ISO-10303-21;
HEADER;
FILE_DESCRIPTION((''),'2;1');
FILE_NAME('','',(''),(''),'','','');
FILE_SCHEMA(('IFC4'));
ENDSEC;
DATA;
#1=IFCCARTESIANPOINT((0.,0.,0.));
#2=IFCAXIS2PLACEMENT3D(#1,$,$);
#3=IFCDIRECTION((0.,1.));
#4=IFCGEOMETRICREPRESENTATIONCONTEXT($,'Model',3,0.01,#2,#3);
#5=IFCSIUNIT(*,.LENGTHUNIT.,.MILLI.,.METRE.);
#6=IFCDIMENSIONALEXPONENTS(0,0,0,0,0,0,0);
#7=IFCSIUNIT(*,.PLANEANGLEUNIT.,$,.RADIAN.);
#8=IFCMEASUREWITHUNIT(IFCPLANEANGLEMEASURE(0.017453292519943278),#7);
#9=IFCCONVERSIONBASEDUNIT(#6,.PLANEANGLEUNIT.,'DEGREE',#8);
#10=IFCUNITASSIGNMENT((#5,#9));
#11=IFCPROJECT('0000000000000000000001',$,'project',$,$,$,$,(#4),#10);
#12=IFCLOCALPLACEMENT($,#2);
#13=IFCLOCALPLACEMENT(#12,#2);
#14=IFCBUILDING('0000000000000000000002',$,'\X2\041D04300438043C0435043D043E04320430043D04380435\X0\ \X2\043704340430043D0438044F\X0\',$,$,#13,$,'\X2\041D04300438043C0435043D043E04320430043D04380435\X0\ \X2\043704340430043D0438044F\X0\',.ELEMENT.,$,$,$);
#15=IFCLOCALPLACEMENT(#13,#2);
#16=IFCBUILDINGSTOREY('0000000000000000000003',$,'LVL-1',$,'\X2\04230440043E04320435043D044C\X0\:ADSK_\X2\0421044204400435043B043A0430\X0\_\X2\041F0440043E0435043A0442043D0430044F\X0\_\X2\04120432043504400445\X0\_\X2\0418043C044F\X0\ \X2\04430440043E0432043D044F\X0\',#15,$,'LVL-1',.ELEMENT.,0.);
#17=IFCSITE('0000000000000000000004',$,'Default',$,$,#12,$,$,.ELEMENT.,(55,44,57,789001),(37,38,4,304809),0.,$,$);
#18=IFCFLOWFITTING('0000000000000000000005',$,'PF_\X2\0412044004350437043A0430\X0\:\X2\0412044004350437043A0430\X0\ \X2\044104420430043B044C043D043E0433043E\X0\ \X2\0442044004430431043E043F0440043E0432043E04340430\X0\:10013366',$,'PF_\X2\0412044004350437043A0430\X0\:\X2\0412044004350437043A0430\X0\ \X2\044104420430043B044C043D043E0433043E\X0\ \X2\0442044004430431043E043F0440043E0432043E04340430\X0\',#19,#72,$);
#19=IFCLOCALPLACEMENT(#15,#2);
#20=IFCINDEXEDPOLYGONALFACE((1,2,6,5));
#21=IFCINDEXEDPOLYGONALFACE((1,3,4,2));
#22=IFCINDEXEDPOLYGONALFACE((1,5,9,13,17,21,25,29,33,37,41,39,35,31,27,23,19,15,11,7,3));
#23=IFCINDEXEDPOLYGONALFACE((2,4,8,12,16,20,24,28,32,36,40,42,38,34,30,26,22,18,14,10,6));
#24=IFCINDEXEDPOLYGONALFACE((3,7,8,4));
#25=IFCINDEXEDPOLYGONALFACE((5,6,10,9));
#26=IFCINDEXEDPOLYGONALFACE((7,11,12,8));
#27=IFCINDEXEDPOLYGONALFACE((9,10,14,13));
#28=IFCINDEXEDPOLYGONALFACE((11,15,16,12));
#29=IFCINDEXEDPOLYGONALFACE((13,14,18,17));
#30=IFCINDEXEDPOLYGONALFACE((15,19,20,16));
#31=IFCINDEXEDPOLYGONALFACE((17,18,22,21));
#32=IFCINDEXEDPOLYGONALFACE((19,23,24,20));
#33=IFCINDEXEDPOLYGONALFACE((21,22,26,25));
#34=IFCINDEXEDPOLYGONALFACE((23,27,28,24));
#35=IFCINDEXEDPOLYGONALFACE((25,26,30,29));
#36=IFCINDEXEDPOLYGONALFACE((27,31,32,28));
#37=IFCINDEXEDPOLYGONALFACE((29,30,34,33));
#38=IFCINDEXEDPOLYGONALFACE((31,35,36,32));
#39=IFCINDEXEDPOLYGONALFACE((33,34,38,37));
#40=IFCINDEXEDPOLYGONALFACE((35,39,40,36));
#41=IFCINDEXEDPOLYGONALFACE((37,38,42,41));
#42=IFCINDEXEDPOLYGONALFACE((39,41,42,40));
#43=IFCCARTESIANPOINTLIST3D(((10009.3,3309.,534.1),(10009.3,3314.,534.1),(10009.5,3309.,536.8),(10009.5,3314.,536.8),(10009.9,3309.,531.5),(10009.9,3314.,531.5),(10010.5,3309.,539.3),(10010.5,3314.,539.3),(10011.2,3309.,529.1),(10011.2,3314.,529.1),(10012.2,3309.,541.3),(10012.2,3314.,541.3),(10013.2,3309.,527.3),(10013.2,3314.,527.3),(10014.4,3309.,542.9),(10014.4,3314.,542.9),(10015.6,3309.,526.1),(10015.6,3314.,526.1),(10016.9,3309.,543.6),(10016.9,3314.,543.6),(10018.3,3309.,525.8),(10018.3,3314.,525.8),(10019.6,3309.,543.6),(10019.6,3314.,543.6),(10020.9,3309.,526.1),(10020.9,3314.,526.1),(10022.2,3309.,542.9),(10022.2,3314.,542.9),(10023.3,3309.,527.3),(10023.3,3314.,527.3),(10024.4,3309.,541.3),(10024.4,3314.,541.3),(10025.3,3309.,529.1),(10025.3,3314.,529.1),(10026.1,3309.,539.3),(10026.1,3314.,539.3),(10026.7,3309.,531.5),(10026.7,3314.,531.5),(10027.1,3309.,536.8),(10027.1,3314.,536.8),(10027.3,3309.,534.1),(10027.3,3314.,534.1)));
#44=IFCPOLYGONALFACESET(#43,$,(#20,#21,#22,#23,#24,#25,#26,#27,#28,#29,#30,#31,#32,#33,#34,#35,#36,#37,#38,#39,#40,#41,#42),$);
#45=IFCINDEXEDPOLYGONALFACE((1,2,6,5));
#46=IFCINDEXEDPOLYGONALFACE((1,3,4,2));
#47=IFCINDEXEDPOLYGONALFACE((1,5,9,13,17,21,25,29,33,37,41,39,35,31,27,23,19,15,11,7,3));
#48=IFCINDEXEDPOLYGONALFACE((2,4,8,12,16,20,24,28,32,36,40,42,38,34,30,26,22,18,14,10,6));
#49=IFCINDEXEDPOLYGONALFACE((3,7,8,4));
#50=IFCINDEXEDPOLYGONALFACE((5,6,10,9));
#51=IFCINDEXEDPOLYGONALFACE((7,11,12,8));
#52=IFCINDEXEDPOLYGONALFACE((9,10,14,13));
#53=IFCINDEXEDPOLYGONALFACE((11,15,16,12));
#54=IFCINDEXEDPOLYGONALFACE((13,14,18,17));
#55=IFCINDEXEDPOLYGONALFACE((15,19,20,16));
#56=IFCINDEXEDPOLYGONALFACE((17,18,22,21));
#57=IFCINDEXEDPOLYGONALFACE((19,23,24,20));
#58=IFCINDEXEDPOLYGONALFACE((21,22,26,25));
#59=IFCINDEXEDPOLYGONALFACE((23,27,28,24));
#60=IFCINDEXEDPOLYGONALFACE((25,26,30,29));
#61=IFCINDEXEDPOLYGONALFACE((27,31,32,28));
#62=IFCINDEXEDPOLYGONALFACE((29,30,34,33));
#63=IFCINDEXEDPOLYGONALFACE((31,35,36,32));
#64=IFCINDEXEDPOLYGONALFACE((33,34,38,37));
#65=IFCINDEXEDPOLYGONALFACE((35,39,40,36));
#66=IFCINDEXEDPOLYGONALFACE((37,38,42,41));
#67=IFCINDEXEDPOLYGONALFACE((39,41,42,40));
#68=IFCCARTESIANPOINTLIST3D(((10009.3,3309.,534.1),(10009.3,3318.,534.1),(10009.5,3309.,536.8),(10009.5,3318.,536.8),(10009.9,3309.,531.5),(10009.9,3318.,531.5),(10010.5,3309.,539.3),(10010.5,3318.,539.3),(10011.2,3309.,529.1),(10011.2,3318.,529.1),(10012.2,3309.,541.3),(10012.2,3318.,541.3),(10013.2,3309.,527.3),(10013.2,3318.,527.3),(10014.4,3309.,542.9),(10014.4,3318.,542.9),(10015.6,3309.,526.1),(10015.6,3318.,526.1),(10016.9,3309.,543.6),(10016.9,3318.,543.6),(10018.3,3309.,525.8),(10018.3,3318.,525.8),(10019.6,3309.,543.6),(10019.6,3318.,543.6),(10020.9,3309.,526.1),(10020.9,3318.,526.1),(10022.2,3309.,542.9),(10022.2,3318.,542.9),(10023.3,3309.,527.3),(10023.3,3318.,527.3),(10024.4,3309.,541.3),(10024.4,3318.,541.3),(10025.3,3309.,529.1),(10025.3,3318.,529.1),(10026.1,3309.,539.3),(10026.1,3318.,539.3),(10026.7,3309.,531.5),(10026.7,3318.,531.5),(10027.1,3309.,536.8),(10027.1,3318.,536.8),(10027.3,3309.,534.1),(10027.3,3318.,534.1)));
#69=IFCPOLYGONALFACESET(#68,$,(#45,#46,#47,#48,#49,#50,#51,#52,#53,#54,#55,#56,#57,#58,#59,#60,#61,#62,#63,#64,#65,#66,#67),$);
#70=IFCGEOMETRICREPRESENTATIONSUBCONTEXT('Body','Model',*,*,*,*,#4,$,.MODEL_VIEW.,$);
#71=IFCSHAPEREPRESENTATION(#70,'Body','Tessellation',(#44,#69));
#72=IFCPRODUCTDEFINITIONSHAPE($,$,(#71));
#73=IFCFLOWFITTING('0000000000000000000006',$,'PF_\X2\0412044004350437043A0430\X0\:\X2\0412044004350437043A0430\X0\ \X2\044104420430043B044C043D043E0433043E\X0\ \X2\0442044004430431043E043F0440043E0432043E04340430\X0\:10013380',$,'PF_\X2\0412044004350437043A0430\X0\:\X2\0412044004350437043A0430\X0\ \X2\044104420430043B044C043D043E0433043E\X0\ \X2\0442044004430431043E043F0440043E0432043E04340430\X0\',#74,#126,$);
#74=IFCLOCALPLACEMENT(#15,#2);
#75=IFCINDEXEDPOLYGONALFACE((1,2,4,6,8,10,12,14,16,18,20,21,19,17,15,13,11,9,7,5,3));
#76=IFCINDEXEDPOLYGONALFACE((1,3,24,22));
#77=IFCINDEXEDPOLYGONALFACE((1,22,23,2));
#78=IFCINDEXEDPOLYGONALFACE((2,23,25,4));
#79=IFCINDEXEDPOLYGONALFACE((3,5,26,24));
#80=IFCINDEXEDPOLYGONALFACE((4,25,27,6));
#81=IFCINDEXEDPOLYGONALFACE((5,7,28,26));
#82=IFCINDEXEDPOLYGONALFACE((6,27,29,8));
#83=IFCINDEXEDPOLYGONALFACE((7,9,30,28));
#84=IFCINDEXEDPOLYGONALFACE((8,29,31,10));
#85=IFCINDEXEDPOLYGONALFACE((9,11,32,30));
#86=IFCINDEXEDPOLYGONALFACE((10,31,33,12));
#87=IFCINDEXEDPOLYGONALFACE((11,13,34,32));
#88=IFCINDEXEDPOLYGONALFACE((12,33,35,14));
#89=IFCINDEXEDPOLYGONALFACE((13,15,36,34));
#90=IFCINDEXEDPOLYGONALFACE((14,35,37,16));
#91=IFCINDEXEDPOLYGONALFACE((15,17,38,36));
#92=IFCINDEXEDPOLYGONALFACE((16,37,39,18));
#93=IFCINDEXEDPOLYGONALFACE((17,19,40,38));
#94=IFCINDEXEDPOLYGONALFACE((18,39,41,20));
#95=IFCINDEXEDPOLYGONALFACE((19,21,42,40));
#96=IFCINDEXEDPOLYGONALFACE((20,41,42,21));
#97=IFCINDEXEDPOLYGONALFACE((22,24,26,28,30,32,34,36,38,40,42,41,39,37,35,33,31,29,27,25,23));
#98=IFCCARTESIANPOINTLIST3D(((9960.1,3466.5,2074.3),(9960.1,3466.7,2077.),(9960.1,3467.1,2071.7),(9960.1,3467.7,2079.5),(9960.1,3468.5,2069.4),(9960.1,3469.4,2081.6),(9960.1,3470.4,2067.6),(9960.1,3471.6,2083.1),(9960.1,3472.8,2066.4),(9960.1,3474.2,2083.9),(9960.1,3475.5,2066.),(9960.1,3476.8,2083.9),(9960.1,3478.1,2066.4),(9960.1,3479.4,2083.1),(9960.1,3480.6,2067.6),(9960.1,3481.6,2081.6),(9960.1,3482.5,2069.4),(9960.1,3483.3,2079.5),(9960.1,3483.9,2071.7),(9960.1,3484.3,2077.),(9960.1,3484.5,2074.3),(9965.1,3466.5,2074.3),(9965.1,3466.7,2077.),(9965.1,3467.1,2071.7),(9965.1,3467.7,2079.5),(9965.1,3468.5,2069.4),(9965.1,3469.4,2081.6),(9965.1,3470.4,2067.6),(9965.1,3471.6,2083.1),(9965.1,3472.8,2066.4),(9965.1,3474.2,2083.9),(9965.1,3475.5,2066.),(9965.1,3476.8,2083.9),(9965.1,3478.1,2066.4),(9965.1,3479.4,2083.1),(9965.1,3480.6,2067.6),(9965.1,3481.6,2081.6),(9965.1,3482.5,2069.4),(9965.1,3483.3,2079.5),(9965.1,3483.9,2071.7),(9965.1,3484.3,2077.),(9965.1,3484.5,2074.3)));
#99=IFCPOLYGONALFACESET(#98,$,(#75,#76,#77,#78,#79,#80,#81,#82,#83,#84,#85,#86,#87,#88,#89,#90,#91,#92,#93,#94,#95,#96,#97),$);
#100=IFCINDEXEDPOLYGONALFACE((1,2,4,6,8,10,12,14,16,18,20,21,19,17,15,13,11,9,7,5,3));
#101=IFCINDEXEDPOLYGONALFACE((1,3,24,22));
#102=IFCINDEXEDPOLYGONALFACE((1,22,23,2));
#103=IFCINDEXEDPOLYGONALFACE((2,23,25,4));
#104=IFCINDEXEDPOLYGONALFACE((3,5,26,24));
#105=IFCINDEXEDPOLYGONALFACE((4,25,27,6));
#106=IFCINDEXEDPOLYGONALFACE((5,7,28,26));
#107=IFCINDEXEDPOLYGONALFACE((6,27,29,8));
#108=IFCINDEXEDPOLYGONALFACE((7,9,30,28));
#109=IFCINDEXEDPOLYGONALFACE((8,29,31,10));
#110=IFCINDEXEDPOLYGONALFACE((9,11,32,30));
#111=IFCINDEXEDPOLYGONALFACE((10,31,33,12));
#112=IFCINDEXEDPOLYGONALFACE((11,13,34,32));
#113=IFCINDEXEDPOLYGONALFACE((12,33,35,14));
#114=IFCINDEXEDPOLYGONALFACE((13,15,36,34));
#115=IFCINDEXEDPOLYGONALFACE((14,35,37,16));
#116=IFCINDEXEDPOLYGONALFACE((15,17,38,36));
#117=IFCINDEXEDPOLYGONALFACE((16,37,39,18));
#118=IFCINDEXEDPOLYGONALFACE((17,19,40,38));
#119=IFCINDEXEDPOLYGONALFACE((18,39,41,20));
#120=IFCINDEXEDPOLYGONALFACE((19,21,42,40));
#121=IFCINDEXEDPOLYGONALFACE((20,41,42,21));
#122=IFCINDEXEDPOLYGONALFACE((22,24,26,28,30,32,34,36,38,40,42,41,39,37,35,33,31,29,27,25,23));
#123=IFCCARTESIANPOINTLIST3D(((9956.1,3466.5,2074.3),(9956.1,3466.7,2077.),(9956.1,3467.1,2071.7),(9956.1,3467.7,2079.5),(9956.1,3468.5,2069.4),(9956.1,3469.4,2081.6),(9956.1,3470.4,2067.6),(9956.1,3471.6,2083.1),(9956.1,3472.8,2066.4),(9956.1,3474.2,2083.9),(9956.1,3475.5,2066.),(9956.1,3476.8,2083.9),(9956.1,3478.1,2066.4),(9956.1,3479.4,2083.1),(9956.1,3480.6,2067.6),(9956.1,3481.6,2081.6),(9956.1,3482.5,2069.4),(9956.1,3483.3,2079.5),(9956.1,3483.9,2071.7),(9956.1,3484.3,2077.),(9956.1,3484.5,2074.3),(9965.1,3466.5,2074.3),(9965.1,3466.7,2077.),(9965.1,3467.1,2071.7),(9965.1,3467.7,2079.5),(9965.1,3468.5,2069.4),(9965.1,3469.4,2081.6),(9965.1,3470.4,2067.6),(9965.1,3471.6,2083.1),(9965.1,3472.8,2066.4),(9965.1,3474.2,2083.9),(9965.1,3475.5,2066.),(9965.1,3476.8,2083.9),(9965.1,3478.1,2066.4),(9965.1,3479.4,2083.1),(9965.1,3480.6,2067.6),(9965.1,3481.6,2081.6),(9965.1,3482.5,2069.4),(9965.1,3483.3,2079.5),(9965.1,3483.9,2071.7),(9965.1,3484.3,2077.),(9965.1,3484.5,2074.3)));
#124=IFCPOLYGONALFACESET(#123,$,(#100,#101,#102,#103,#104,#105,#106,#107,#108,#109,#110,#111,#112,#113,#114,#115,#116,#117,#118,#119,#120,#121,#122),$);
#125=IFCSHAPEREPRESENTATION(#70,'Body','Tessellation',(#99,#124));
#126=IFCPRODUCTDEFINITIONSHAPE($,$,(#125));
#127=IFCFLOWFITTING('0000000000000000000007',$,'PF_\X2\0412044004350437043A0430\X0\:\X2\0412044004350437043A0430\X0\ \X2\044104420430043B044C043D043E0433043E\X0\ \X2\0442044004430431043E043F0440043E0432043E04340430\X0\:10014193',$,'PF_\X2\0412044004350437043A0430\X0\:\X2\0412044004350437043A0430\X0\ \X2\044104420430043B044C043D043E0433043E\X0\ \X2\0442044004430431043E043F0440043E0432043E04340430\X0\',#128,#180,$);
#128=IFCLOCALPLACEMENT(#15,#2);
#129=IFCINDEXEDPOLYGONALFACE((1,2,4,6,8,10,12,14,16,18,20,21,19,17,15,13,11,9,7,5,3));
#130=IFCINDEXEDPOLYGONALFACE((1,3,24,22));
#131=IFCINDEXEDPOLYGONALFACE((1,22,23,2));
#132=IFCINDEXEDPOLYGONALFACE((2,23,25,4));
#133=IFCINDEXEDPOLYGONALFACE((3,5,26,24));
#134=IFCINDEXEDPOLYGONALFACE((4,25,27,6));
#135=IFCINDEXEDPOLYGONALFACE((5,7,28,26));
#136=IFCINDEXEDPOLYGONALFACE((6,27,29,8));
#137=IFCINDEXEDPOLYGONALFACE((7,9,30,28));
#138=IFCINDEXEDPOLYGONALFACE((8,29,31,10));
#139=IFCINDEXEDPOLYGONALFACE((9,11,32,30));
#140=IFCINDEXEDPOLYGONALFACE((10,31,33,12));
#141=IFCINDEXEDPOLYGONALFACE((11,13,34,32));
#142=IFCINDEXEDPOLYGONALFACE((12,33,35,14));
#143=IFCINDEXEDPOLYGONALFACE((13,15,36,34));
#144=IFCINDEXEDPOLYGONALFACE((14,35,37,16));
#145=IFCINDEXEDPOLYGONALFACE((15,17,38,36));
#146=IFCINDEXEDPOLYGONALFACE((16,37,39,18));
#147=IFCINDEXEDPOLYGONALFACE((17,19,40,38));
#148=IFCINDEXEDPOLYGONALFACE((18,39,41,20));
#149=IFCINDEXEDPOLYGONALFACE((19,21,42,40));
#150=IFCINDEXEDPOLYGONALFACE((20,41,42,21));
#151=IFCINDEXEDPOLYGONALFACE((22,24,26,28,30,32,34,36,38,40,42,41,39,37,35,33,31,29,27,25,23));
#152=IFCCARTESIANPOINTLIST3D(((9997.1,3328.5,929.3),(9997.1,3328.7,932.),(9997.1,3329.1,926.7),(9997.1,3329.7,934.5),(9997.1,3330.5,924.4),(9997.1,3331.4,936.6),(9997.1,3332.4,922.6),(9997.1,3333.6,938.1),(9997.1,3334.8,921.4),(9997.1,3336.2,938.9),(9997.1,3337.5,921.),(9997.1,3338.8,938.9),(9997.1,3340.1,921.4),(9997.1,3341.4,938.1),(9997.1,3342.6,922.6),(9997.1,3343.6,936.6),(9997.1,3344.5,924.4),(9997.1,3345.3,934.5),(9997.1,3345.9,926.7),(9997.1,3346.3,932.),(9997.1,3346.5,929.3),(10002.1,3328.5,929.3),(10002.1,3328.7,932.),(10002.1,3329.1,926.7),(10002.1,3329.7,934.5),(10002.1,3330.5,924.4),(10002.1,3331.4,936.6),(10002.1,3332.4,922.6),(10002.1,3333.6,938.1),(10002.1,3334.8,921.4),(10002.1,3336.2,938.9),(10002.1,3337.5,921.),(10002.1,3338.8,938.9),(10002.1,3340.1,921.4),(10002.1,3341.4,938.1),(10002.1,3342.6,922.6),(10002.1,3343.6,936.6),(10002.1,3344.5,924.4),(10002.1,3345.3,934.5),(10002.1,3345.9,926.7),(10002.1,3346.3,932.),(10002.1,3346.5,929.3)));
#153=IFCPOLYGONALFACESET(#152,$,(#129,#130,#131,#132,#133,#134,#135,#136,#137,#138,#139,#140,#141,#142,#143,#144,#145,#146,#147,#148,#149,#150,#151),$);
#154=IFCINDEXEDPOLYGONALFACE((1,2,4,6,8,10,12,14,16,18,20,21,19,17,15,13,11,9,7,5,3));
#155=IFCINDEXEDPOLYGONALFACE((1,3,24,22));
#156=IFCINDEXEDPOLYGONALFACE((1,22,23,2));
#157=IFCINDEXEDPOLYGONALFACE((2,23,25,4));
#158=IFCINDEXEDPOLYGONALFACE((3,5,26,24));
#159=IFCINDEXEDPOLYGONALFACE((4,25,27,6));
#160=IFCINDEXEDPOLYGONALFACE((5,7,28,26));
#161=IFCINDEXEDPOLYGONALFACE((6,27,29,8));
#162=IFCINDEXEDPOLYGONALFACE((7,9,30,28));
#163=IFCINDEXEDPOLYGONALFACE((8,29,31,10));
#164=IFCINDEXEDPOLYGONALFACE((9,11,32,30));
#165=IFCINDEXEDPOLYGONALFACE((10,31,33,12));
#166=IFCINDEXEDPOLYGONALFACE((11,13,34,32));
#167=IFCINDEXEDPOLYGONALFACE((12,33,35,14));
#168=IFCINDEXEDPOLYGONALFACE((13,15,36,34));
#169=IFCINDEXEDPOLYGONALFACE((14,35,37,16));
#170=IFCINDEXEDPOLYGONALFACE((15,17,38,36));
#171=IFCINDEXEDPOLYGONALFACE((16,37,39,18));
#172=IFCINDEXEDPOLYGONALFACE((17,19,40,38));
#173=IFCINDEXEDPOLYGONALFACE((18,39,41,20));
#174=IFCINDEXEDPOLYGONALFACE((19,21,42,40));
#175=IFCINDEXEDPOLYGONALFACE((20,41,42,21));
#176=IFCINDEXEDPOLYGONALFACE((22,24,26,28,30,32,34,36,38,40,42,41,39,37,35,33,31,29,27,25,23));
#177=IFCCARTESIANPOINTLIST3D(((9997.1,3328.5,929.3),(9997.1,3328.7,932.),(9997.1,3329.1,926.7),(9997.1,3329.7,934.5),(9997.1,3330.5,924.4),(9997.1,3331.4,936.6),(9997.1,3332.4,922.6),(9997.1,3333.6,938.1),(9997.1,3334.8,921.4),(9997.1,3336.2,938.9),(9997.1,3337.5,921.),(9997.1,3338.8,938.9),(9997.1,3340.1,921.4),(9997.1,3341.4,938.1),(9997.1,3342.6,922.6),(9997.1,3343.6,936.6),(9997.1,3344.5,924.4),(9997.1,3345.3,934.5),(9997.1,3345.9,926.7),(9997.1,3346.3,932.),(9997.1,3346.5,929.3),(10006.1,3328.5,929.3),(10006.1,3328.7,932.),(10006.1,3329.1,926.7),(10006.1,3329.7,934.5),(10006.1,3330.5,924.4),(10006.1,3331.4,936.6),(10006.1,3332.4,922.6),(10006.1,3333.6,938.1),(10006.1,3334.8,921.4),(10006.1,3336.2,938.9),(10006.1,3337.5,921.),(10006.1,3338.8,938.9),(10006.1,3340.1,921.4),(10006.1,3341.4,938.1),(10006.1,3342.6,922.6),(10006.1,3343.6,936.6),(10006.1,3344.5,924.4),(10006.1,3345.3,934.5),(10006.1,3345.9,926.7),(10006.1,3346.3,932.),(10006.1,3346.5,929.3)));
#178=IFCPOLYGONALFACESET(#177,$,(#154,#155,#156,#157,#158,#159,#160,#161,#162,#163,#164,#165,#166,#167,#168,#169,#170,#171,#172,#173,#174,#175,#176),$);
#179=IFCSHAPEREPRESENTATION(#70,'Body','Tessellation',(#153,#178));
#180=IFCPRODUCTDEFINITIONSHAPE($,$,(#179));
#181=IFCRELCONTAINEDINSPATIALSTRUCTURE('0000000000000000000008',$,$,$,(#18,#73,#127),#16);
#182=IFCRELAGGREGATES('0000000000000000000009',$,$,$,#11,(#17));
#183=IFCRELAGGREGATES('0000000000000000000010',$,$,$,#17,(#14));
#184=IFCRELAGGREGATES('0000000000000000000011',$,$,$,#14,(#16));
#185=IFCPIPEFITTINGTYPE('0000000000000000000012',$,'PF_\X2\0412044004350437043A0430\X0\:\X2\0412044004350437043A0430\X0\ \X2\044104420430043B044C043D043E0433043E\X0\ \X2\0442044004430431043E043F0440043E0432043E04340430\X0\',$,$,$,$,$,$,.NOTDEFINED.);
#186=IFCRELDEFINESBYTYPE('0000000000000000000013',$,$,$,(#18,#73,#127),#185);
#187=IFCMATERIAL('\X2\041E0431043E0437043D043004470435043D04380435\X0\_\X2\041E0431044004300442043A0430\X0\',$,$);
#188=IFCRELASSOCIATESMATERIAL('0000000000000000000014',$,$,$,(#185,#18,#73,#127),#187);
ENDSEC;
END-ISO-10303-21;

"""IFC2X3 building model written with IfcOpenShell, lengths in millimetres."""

from ifc_helpers import new_model, entity, si_unit, converted_unit, direction, frame, frame_2d, origin, place, context, subcontext, project, spatial, circle, extrude, source, transform, mapped, material, type_object, type_shapes, element, save


model = new_model("IFC2X3")

# Units and contexts
model_context = context("Model", 3, precision=0.01, world=origin(), true_north=direction((0.0, 1.0)))
body_context = subcontext(model_context, "Body", "Model", "MODEL_VIEW")
ifc_project = project(units=[si_unit("LENGTHUNIT", "METRE", prefix="MILLI"), converted_unit("PLANEANGLEUNIT", "DEGREE", entity("IfcPlaneAngleMeasure", 0.017453292519943278), si_unit("PLANEANGLEUNIT", "RADIAN"), dimensions=[0, 0, 0, 0, 0, 0, 0])], contexts=[model_context])

# Site, building, storey
site_placement = place(None, origin())
site = spatial("IfcSite", under=ifc_project, at=site_placement, Name="Default", CompositionType="ELEMENT", RefLatitude=(55, 44, 57, 789001), RefLongitude=(37, 38, 4, 304809), RefElevation=0.0)
building_placement = place(site_placement, origin())
building = spatial("IfcBuilding", under=site, at=building_placement, Name="Наименование здания", LongName="Наименование здания", CompositionType="ELEMENT")
storey_placement = place(building_placement, origin())
storey = spatial("IfcBuildingStorey", under=building, at=storey_placement, Name="LVL-1", ObjectType="Уровень:ADSK_Стрелка_Проектная_Вверх_Имя уровня", LongName="LVL-1", CompositionType="ELEMENT", Elevation=0.0)

# Flow fittings
ifc_material_1 = material(Name="Обозначение_Обратка")
pipe_fitting_type_1 = type_object("IfcPipeFittingType", Name="PF_Врезка:Врезка стального трубопровода", PredefinedType="NOTDEFINED", material=ifc_material_1)
shared_shape_1 = source(origin(), body_context, "Body", "SweptSolid", [
    extrude(circle(Radius=9.0, at=frame_2d((0.0, 0.0), x_axis=(1.0, 0.0))), frame((-5.0, 0.0, 0.0), z_axis=(1.0, 0.0, 0.0), x_axis=(0.0, -1.0, 0.0)), (0.0, 0.0, 1.0), 5.0),
    extrude(circle(Radius=9.0, at=frame_2d((0.0, 0.0), x_axis=(1.0, 0.0))), frame((-9.0, 0.0, 0.0), z_axis=(1.0, 0.0, 0.0), x_axis=(0.0, -1.0, 0.0)), (0.0, 0.0, 1.0), 9.0),
])
type_shapes(pipe_fitting_type_1, [shared_shape_1])
for number, where, z_axis, x_axis, name in (
    (1, (10018.3, 3309.0, 534.8), (-1.0, 0.0, 0.0), (0.0, -1.0, 0.0), "PF_Врезка:Врезка стального трубопровода:10013366"),
    (2, (9965.1, 3475.5, 2075.0), (0.0, -1.0, 0.0), (1.0, 0.0, 0.0), "PF_Врезка:Врезка стального трубопровода:10013380"),
    (3, (9997.1, 3337.5, 930.0), (0.0, 1.0, 0.0), (-1.0, 0.0, 0.0), "PF_Врезка:Врезка стального трубопровода:10014193"),
):
    element("IfcFlowFitting", number, at=place(storey_placement, frame(where, z_axis=z_axis, x_axis=x_axis)), inside=storey, type_object=pipe_fitting_type_1, material=ifc_material_1, Name=name, ObjectType="PF_Врезка:Врезка стального трубопровода", context=body_context, shape_type="MappedRepresentation", body=[
        mapped(shared_shape_1, transform((0.0, 0.0, 0.0), scale=1.0)),
    ])

save(model, "model.ifc")
